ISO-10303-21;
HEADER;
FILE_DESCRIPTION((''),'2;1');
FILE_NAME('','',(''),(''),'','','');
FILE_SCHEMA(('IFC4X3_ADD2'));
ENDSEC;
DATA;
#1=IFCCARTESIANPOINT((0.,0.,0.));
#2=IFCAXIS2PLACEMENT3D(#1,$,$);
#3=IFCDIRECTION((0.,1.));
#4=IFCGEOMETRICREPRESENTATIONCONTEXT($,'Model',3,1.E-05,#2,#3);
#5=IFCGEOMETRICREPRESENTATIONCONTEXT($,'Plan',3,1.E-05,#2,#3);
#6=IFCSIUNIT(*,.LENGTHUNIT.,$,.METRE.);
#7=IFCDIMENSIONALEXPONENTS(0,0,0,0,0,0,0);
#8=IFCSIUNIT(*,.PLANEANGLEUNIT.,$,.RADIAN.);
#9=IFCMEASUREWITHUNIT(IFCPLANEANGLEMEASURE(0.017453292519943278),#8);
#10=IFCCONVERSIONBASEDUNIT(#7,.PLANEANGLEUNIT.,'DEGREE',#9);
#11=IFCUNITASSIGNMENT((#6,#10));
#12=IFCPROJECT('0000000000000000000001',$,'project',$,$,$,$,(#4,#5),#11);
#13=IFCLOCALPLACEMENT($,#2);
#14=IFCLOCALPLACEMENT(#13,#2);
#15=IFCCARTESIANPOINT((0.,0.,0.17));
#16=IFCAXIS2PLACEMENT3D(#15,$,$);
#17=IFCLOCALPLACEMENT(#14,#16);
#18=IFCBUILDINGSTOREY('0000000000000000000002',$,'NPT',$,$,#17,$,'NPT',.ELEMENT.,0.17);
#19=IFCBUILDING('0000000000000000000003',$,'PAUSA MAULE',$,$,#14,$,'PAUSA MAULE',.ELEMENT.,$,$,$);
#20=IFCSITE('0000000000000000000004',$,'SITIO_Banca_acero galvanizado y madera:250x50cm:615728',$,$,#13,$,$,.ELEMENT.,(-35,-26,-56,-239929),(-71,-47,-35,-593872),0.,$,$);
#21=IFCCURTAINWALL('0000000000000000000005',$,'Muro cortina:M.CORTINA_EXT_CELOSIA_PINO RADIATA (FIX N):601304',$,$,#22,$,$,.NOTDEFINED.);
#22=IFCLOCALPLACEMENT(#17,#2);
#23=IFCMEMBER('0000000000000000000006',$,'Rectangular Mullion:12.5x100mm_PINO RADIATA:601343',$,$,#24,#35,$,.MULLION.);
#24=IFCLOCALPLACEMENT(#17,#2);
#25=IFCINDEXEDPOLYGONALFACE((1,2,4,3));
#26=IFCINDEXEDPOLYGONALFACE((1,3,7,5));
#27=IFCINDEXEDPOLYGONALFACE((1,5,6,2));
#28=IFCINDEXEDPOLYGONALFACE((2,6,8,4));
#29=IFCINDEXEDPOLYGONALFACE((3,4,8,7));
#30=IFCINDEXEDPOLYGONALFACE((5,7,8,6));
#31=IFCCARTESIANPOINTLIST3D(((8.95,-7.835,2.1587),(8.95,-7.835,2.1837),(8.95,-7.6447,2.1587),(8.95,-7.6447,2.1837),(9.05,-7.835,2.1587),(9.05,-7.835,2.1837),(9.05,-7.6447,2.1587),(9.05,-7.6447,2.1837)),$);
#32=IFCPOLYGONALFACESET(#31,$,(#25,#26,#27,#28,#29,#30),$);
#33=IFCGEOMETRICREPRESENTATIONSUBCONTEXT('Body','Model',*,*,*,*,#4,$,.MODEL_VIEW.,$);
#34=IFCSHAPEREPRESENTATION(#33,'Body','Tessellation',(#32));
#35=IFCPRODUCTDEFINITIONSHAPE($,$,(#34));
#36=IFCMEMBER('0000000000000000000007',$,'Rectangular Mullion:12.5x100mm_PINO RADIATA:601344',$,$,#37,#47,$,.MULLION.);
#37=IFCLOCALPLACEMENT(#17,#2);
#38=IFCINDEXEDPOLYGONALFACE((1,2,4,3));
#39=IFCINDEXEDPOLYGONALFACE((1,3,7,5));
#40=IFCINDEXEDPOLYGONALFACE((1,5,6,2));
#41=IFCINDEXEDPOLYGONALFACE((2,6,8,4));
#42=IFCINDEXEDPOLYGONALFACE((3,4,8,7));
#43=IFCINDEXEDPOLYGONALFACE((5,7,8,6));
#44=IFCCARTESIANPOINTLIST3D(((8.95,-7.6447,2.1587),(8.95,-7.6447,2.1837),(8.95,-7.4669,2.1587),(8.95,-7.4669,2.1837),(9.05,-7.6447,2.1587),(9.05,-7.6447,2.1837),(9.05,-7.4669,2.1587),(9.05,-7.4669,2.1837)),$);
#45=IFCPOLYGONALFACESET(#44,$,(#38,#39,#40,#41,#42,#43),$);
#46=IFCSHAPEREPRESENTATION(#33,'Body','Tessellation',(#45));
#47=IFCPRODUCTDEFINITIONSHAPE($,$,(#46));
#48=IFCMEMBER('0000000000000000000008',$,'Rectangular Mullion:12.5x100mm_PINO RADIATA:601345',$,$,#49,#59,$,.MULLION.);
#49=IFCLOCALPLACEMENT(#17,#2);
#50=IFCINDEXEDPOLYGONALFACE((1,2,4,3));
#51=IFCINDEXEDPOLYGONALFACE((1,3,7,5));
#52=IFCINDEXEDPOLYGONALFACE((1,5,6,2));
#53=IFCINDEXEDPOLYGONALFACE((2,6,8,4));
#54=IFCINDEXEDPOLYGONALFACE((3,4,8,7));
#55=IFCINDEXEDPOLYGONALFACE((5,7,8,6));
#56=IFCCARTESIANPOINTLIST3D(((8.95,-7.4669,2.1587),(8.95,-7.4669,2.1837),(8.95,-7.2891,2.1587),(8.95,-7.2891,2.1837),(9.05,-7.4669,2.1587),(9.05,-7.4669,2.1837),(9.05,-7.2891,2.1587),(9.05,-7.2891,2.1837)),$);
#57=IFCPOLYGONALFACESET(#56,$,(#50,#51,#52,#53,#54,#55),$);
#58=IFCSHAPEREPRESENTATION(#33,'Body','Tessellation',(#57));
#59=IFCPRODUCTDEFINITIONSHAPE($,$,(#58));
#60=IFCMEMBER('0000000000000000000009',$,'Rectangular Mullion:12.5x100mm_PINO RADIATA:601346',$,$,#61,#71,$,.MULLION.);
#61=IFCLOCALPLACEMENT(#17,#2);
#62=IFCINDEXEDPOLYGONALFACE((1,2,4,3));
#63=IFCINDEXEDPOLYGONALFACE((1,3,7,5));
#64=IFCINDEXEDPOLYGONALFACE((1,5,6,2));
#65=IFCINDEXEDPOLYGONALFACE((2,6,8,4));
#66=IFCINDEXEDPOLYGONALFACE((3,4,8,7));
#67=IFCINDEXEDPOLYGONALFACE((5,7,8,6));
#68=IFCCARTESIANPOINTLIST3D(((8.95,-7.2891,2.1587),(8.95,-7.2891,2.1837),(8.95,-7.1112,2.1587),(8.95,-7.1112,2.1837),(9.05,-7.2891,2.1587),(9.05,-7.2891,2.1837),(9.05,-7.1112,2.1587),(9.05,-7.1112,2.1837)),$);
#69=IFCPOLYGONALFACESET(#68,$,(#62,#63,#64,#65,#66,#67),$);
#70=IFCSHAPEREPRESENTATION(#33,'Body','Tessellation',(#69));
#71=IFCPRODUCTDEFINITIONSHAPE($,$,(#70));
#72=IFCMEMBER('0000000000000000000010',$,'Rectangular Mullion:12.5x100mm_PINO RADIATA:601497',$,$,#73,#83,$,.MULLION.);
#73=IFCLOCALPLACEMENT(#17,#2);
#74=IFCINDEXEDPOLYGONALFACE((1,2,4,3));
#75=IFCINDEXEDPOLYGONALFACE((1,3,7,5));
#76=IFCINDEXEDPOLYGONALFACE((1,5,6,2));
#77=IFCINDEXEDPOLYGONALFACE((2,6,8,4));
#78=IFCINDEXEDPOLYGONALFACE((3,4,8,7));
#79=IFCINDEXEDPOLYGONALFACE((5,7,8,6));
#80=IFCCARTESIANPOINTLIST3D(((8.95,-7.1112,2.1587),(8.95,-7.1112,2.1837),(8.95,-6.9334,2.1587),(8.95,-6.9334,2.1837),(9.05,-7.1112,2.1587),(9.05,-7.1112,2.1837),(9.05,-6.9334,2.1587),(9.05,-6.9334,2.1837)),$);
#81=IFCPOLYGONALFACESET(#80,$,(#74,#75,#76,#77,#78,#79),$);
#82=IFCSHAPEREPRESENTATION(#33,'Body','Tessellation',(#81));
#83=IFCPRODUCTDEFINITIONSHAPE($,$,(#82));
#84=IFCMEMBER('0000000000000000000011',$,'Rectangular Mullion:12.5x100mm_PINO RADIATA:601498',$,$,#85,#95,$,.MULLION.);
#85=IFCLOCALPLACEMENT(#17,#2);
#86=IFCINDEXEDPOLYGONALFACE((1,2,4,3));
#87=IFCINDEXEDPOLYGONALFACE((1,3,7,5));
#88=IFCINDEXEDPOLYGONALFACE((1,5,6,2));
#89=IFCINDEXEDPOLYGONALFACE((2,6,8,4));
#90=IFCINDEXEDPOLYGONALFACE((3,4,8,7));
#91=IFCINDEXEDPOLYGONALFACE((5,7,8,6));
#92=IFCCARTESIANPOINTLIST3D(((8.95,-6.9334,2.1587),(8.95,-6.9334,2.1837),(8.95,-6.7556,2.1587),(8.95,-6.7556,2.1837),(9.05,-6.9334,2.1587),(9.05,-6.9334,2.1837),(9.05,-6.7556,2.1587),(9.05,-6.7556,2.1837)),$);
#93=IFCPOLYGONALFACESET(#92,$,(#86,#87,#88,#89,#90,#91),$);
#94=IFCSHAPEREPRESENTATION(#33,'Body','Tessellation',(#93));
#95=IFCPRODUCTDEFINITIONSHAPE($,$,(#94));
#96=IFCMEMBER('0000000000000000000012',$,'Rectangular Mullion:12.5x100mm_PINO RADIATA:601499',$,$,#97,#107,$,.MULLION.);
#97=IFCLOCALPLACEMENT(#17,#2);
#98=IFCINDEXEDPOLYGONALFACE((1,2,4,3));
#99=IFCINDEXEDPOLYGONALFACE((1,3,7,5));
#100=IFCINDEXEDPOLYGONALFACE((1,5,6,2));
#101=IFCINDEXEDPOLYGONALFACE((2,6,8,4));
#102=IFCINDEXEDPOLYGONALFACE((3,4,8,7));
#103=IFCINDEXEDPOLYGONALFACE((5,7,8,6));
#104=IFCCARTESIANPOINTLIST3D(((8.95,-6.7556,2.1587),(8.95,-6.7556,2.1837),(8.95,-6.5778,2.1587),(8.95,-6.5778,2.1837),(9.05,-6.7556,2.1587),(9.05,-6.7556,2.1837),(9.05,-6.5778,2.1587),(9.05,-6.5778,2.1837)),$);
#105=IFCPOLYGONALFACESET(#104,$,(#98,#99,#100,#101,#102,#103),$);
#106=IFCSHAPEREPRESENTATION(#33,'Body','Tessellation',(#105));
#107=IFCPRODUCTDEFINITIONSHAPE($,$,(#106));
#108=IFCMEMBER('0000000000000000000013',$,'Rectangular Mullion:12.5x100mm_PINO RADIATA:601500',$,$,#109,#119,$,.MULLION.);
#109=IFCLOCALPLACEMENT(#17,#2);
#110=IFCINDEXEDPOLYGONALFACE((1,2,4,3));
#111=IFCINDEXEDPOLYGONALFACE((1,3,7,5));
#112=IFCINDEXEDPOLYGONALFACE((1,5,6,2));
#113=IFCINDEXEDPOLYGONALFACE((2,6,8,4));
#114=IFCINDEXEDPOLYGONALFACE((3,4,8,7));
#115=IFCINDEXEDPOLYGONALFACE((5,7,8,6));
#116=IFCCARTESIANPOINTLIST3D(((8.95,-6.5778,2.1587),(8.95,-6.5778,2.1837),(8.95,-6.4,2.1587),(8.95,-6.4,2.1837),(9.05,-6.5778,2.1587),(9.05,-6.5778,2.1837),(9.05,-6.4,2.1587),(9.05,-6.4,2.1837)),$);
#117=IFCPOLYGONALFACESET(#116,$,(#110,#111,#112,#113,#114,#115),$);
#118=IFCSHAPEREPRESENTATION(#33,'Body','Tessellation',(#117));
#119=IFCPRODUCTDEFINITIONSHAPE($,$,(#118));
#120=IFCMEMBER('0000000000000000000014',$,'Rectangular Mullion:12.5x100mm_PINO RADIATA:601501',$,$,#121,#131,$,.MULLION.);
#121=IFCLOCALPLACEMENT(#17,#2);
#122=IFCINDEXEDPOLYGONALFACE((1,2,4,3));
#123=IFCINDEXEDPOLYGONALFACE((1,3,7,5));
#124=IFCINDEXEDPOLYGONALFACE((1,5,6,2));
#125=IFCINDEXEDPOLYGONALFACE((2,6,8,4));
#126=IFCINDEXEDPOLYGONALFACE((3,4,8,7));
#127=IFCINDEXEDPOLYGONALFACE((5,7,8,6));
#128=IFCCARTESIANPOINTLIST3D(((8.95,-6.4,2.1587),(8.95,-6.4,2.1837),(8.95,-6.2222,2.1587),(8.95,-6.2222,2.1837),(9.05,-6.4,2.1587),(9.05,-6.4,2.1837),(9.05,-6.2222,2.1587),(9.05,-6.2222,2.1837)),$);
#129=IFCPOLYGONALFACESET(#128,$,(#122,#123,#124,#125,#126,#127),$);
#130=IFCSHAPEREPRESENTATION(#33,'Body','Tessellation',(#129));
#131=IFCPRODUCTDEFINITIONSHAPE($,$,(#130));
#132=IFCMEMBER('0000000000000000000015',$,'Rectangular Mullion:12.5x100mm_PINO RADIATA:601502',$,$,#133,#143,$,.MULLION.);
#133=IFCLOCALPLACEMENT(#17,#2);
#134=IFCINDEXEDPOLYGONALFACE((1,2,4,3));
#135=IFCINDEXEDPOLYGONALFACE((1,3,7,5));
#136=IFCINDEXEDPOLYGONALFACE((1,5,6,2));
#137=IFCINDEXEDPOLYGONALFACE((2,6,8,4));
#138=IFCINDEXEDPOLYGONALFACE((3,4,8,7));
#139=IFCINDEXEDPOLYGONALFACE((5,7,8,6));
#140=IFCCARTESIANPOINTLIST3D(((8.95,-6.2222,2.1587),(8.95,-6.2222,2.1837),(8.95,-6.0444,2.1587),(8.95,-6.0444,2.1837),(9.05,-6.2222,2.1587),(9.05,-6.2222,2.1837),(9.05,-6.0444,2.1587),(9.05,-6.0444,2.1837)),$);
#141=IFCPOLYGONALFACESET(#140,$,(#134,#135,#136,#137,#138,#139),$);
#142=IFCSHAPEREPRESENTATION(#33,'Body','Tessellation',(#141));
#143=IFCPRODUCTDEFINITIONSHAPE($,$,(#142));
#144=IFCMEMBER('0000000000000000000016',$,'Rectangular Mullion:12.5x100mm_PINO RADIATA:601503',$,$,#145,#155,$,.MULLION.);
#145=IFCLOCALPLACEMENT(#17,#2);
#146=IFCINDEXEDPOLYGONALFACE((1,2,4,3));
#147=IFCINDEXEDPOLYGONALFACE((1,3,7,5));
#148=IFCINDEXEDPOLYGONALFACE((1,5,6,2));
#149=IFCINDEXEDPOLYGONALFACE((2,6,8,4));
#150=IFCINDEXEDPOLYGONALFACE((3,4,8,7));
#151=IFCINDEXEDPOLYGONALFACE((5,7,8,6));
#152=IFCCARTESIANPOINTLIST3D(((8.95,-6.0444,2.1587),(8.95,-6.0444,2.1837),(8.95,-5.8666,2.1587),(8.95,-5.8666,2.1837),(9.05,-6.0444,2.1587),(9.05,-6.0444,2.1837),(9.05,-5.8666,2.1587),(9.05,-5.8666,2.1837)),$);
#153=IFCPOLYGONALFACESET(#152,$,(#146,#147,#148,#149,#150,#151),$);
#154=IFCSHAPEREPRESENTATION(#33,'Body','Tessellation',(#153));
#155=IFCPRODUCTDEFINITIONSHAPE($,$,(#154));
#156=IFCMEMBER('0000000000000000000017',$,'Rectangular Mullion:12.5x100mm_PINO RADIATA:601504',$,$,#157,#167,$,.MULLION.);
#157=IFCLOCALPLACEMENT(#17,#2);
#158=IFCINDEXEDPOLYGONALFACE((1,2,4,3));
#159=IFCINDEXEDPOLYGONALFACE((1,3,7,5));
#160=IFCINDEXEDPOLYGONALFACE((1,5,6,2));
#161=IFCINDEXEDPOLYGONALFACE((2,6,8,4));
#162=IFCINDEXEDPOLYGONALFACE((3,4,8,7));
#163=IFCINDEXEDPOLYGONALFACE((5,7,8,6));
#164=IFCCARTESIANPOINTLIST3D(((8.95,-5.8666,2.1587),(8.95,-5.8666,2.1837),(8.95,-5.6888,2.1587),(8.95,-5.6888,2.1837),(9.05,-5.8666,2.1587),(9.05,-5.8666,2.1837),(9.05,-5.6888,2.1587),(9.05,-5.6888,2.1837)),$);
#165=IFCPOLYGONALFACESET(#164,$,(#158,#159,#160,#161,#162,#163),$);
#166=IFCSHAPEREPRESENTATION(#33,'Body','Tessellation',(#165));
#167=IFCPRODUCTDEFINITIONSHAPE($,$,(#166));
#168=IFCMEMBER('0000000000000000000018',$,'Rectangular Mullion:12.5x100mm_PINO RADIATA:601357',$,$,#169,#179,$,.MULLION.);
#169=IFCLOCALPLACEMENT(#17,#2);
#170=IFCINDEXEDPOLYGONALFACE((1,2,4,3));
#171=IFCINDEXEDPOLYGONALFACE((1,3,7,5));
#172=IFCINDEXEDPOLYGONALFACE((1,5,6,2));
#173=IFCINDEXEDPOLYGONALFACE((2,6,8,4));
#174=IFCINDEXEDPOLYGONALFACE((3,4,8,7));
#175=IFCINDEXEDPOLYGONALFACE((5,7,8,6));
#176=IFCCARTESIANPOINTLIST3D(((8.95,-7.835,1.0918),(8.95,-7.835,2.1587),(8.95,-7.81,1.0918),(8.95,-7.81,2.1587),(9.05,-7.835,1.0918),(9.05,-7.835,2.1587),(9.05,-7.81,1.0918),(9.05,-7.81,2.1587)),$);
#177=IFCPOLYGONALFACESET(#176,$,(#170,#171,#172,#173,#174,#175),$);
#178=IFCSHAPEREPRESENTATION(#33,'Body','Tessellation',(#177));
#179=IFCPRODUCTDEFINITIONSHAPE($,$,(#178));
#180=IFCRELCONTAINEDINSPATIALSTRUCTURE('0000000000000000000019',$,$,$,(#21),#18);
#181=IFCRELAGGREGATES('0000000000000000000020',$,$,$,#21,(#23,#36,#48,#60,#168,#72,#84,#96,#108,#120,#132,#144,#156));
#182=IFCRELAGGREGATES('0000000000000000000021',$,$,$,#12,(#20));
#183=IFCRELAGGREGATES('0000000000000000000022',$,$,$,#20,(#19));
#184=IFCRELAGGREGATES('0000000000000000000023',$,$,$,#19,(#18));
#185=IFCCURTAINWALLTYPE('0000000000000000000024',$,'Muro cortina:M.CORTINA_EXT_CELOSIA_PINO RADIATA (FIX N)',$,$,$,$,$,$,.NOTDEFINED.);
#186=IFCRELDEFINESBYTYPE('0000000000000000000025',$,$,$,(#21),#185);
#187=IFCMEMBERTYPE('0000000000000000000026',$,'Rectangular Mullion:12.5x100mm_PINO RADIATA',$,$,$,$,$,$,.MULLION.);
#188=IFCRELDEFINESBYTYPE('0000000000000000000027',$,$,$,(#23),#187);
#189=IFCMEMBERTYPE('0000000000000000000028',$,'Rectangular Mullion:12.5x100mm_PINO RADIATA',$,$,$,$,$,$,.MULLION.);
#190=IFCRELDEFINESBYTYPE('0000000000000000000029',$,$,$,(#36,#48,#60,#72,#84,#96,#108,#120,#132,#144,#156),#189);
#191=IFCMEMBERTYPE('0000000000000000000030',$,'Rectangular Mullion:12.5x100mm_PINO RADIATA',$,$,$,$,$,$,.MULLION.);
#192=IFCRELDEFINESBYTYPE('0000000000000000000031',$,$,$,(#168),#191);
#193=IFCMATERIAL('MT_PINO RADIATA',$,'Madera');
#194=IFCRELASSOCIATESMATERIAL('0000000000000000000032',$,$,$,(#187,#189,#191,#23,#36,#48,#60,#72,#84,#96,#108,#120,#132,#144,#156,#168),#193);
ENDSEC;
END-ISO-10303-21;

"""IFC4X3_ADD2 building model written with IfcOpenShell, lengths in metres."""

from ifc_helpers import new_model, entity, si_unit, converted_unit, direction, frame, frame_2d, origin, place, context, subcontext, project, spatial, rectangle, extrude, source, transform, mapped, material, material_profile, profile_set, profile_usage, type_object, type_shapes, element, aggregate, save


model = new_model("IFC4X3_ADD2")

# Units and contexts
model_context = context("Model", 3, precision=1e-05, world=origin(), true_north=direction((0.0, 1.0)))
plan_context = context("Plan", 3, precision=1e-05, world=origin(), true_north=direction((0.0, 1.0)))
body_context = subcontext(model_context, "Body", "Model", "MODEL_VIEW")
ifc_project = project(units=[si_unit("LENGTHUNIT", "METRE"), converted_unit("PLANEANGLEUNIT", "DEGREE", entity("IfcPlaneAngleMeasure", 0.017453292519943278), si_unit("PLANEANGLEUNIT", "RADIAN"), dimensions=[0, 0, 0, 0, 0, 0, 0])], contexts=[model_context, plan_context])

# Site, building, storey
site_placement = place(None, origin())
site = spatial("IfcSite", under=ifc_project, at=site_placement, Name="SITIO_Banca_acero galvanizado y madera:250x50cm:615728", CompositionType="ELEMENT", RefLatitude=(-35, -26, -56, -239929), RefLongitude=(-71, -47, -35, -593872), RefElevation=0.0)
building_placement = place(site_placement, origin())
building = spatial("IfcBuilding", under=site, at=building_placement, Name="PAUSA MAULE", LongName="PAUSA MAULE", CompositionType="ELEMENT")
storey_placement = place(building_placement, frame((0.0, 0.0, 0.17)))
storey = spatial("IfcBuildingStorey", under=building, at=storey_placement, Name="NPT", LongName="NPT", CompositionType="ELEMENT", Elevation=0.17)

# Curtain wall, members
curtain_wall_type = type_object("IfcCurtainWallType", Name="Muro cortina:M.CORTINA_EXT_CELOSIA_PINO RADIATA (FIX N)", PredefinedType="NOTDEFINED")
curtain_wall_placement = place(storey_placement, frame((0.0, 0.0, -0.17)))
curtain_wall = element("IfcCurtainWall", 1, at=curtain_wall_placement, inside=storey, type_object=curtain_wall_type, Name="Muro cortina:M.CORTINA_EXT_CELOSIA_PINO RADIATA (FIX N):601304", PredefinedType="NOTDEFINED")
ifc_material = material(Name="MT_PINO RADIATA", Category="Madera")
ifc_material_profile = material_profile(ifc_material, rectangle(XDim=0.025, YDim=0.1, at=frame_2d((0.0, 0.0), x_axis=(1.0, 0.0))), Name="12.5x100mm_PINO RADIATA")
ifc_profile_set = profile_set([ifc_material_profile], Name="12.5x100mm_PINO RADIATA")
ifc_profile_usage = profile_usage(ifc_profile_set)
member_type_1 = type_object("IfcMemberType", Name="Rectangular Mullion:12.5x100mm_PINO RADIATA", PredefinedType="MULLION", material=ifc_profile_set)
shared_shape_1 = source(origin(), body_context, "Body", "SweptSolid", [
    extrude(rectangle(XDim=0.025, YDim=0.1, at=frame_2d((0.0, 0.0), x_axis=(1.0, 0.0))), frame((-0.0125, 0.0, -0.1903), z_axis=(0.0, 0.0, 1.0), x_axis=(-1.0, 0.0, 0.0)), (0.0, 0.0, 1.0), 0.1903),
])
type_shapes(member_type_1, [shared_shape_1])
member_1_placement = place(curtain_wall_placement, frame((9.0, -7.6447, 2.3537), z_axis=(0.0, 1.0, 0.0), x_axis=(0.0, 0.0, 1.0)))
member_1 = element("IfcMember", 2, at=member_1_placement, type_object=member_type_1, material=ifc_profile_usage, Name="Rectangular Mullion:12.5x100mm_PINO RADIATA:601343", PredefinedType="MULLION", context=body_context, shape_type="MappedRepresentation", body=[
    mapped(shared_shape_1, transform((0.0, 0.0, 0.0), scale=1.0)),
])
member_type_2 = type_object("IfcMemberType", Name="Rectangular Mullion:12.5x100mm_PINO RADIATA", PredefinedType="MULLION", material=ifc_profile_set)
shared_shape_2 = source(origin(), body_context, "Body", "SweptSolid", [
    extrude(rectangle(XDim=0.025, YDim=0.1, at=frame_2d((0.0, 0.0), x_axis=(1.0, 0.0))), frame((-0.0125, 0.0, -0.1778), z_axis=(0.0, 0.0, 1.0), x_axis=(-1.0, 0.0, 0.0)), (0.0, 0.0, 1.0), 0.1778),
])
type_shapes(member_type_2, [shared_shape_2])
member_2_placement = place(curtain_wall_placement, frame((9.0, -7.4669, 2.3537), z_axis=(0.0, 1.0, 0.0), x_axis=(0.0, 0.0, 1.0)))
member_2 = element("IfcMember", 3, at=member_2_placement, type_object=member_type_2, material=ifc_profile_usage, Name="Rectangular Mullion:12.5x100mm_PINO RADIATA:601344", PredefinedType="MULLION", context=body_context, shape_type="MappedRepresentation", body=[
    mapped(shared_shape_2, transform((0.0, 0.0, 0.0), scale=1.0)),
])
member_3_placement = place(curtain_wall_placement, frame((9.0, -7.2891, 2.3537), z_axis=(0.0, 1.0, 0.0), x_axis=(0.0, 0.0, 1.0)))
member_3 = element("IfcMember", 4, at=member_3_placement, type_object=member_type_2, material=ifc_profile_usage, Name="Rectangular Mullion:12.5x100mm_PINO RADIATA:601345", PredefinedType="MULLION", context=body_context, shape_type="MappedRepresentation", body=[
    mapped(shared_shape_2, transform((0.0, 0.0, 0.0), scale=1.0)),
])
member_4_placement = place(curtain_wall_placement, frame((9.0, -7.1112, 2.3537), z_axis=(0.0, 1.0, 0.0), x_axis=(0.0, 0.0, 1.0)))
member_4 = element("IfcMember", 5, at=member_4_placement, type_object=member_type_2, material=ifc_profile_usage, Name="Rectangular Mullion:12.5x100mm_PINO RADIATA:601346", PredefinedType="MULLION", context=body_context, shape_type="MappedRepresentation", body=[
    mapped(shared_shape_2, transform((0.0, 0.0, 0.0), scale=1.0)),
])
member_5_placement = place(curtain_wall_placement, frame((9.0, -6.9334, 2.3537), z_axis=(0.0, 1.0, 0.0), x_axis=(0.0, 0.0, 1.0)))
member_5 = element("IfcMember", 6, at=member_5_placement, type_object=member_type_2, material=ifc_profile_usage, Name="Rectangular Mullion:12.5x100mm_PINO RADIATA:601497", PredefinedType="MULLION", context=body_context, shape_type="MappedRepresentation", body=[
    mapped(shared_shape_2, transform((0.0, 0.0, 0.0), scale=1.0)),
])
member_6_placement = place(curtain_wall_placement, frame((9.0, -6.7556, 2.3537), z_axis=(0.0, 1.0, 0.0), x_axis=(0.0, 0.0, 1.0)))
member_6 = element("IfcMember", 7, at=member_6_placement, type_object=member_type_2, material=ifc_profile_usage, Name="Rectangular Mullion:12.5x100mm_PINO RADIATA:601498", PredefinedType="MULLION", context=body_context, shape_type="MappedRepresentation", body=[
    mapped(shared_shape_2, transform((0.0, 0.0, 0.0), scale=1.0)),
])
member_7_placement = place(curtain_wall_placement, frame((9.0, -6.5778, 2.3537), z_axis=(0.0, 1.0, 0.0), x_axis=(0.0, 0.0, 1.0)))
member_7 = element("IfcMember", 8, at=member_7_placement, type_object=member_type_2, material=ifc_profile_usage, Name="Rectangular Mullion:12.5x100mm_PINO RADIATA:601499", PredefinedType="MULLION", context=body_context, shape_type="MappedRepresentation", body=[
    mapped(shared_shape_2, transform((0.0, 0.0, 0.0), scale=1.0)),
])
member_8_placement = place(curtain_wall_placement, frame((9.0, -6.4, 2.3537), z_axis=(0.0, 1.0, 0.0), x_axis=(0.0, 0.0, 1.0)))
member_8 = element("IfcMember", 9, at=member_8_placement, type_object=member_type_2, material=ifc_profile_usage, Name="Rectangular Mullion:12.5x100mm_PINO RADIATA:601500", PredefinedType="MULLION", context=body_context, shape_type="MappedRepresentation", body=[
    mapped(shared_shape_2, transform((0.0, 0.0, 0.0), scale=1.0)),
])
member_9_placement = place(curtain_wall_placement, frame((9.0, -6.2222, 2.3537), z_axis=(0.0, 1.0, 0.0), x_axis=(0.0, 0.0, 1.0)))
member_9 = element("IfcMember", 10, at=member_9_placement, type_object=member_type_2, material=ifc_profile_usage, Name="Rectangular Mullion:12.5x100mm_PINO RADIATA:601501", PredefinedType="MULLION", context=body_context, shape_type="MappedRepresentation", body=[
    mapped(shared_shape_2, transform((0.0, 0.0, 0.0), scale=1.0)),
])
member_10_placement = place(curtain_wall_placement, frame((9.0, -6.0444, 2.3537), z_axis=(0.0, 1.0, 0.0), x_axis=(0.0, 0.0, 1.0)))
member_10 = element("IfcMember", 11, at=member_10_placement, type_object=member_type_2, material=ifc_profile_usage, Name="Rectangular Mullion:12.5x100mm_PINO RADIATA:601502", PredefinedType="MULLION", context=body_context, shape_type="MappedRepresentation", body=[
    mapped(shared_shape_2, transform((0.0, 0.0, 0.0), scale=1.0)),
])
member_11_placement = place(curtain_wall_placement, frame((9.0, -5.8666, 2.3537), z_axis=(0.0, 1.0, 0.0), x_axis=(0.0, 0.0, 1.0)))
member_11 = element("IfcMember", 12, at=member_11_placement, type_object=member_type_2, material=ifc_profile_usage, Name="Rectangular Mullion:12.5x100mm_PINO RADIATA:601503", PredefinedType="MULLION", context=body_context, shape_type="MappedRepresentation", body=[
    mapped(shared_shape_2, transform((0.0, 0.0, 0.0), scale=1.0)),
])
member_12_placement = place(curtain_wall_placement, frame((9.0, -5.6888, 2.3537), z_axis=(0.0, 1.0, 0.0), x_axis=(0.0, 0.0, 1.0)))
member_12 = element("IfcMember", 13, at=member_12_placement, type_object=member_type_2, material=ifc_profile_usage, Name="Rectangular Mullion:12.5x100mm_PINO RADIATA:601504", PredefinedType="MULLION", context=body_context, shape_type="MappedRepresentation", body=[
    mapped(shared_shape_2, transform((0.0, 0.0, 0.0), scale=1.0)),
])
member_type_3 = type_object("IfcMemberType", Name="Rectangular Mullion:12.5x100mm_PINO RADIATA", PredefinedType="MULLION", material=ifc_profile_set)
shared_shape_3 = source(origin(), body_context, "Body", "SweptSolid", [
    extrude(rectangle(XDim=0.025, YDim=0.1, at=frame_2d((0.0, 0.0), x_axis=(1.0, 0.0))), frame((-0.0125, 0.0, -1.0668), z_axis=(0.0, 0.0, 1.0), x_axis=(-1.0, 0.0, 0.0)), (0.0, 0.0, 1.0), 1.0668),
])
type_shapes(member_type_3, [shared_shape_3])
member_13_placement = place(curtain_wall_placement, frame((9.0, -7.835, 2.3287), z_axis=(0.0, 0.0, 1.0), x_axis=(0.0, -1.0, 0.0)))
member_13 = element("IfcMember", 14, at=member_13_placement, type_object=member_type_3, material=ifc_profile_usage, Name="Rectangular Mullion:12.5x100mm_PINO RADIATA:601357", PredefinedType="MULLION", context=body_context, shape_type="MappedRepresentation", body=[
    mapped(shared_shape_3, transform((0.0, 0.0, 0.0), scale=1.0)),
])
aggregate(curtain_wall, [member_1, member_2, member_3, member_4, member_13, member_5, member_6, member_7, member_8, member_9, member_10, member_11, member_12])

save(model, "model.ifc")
